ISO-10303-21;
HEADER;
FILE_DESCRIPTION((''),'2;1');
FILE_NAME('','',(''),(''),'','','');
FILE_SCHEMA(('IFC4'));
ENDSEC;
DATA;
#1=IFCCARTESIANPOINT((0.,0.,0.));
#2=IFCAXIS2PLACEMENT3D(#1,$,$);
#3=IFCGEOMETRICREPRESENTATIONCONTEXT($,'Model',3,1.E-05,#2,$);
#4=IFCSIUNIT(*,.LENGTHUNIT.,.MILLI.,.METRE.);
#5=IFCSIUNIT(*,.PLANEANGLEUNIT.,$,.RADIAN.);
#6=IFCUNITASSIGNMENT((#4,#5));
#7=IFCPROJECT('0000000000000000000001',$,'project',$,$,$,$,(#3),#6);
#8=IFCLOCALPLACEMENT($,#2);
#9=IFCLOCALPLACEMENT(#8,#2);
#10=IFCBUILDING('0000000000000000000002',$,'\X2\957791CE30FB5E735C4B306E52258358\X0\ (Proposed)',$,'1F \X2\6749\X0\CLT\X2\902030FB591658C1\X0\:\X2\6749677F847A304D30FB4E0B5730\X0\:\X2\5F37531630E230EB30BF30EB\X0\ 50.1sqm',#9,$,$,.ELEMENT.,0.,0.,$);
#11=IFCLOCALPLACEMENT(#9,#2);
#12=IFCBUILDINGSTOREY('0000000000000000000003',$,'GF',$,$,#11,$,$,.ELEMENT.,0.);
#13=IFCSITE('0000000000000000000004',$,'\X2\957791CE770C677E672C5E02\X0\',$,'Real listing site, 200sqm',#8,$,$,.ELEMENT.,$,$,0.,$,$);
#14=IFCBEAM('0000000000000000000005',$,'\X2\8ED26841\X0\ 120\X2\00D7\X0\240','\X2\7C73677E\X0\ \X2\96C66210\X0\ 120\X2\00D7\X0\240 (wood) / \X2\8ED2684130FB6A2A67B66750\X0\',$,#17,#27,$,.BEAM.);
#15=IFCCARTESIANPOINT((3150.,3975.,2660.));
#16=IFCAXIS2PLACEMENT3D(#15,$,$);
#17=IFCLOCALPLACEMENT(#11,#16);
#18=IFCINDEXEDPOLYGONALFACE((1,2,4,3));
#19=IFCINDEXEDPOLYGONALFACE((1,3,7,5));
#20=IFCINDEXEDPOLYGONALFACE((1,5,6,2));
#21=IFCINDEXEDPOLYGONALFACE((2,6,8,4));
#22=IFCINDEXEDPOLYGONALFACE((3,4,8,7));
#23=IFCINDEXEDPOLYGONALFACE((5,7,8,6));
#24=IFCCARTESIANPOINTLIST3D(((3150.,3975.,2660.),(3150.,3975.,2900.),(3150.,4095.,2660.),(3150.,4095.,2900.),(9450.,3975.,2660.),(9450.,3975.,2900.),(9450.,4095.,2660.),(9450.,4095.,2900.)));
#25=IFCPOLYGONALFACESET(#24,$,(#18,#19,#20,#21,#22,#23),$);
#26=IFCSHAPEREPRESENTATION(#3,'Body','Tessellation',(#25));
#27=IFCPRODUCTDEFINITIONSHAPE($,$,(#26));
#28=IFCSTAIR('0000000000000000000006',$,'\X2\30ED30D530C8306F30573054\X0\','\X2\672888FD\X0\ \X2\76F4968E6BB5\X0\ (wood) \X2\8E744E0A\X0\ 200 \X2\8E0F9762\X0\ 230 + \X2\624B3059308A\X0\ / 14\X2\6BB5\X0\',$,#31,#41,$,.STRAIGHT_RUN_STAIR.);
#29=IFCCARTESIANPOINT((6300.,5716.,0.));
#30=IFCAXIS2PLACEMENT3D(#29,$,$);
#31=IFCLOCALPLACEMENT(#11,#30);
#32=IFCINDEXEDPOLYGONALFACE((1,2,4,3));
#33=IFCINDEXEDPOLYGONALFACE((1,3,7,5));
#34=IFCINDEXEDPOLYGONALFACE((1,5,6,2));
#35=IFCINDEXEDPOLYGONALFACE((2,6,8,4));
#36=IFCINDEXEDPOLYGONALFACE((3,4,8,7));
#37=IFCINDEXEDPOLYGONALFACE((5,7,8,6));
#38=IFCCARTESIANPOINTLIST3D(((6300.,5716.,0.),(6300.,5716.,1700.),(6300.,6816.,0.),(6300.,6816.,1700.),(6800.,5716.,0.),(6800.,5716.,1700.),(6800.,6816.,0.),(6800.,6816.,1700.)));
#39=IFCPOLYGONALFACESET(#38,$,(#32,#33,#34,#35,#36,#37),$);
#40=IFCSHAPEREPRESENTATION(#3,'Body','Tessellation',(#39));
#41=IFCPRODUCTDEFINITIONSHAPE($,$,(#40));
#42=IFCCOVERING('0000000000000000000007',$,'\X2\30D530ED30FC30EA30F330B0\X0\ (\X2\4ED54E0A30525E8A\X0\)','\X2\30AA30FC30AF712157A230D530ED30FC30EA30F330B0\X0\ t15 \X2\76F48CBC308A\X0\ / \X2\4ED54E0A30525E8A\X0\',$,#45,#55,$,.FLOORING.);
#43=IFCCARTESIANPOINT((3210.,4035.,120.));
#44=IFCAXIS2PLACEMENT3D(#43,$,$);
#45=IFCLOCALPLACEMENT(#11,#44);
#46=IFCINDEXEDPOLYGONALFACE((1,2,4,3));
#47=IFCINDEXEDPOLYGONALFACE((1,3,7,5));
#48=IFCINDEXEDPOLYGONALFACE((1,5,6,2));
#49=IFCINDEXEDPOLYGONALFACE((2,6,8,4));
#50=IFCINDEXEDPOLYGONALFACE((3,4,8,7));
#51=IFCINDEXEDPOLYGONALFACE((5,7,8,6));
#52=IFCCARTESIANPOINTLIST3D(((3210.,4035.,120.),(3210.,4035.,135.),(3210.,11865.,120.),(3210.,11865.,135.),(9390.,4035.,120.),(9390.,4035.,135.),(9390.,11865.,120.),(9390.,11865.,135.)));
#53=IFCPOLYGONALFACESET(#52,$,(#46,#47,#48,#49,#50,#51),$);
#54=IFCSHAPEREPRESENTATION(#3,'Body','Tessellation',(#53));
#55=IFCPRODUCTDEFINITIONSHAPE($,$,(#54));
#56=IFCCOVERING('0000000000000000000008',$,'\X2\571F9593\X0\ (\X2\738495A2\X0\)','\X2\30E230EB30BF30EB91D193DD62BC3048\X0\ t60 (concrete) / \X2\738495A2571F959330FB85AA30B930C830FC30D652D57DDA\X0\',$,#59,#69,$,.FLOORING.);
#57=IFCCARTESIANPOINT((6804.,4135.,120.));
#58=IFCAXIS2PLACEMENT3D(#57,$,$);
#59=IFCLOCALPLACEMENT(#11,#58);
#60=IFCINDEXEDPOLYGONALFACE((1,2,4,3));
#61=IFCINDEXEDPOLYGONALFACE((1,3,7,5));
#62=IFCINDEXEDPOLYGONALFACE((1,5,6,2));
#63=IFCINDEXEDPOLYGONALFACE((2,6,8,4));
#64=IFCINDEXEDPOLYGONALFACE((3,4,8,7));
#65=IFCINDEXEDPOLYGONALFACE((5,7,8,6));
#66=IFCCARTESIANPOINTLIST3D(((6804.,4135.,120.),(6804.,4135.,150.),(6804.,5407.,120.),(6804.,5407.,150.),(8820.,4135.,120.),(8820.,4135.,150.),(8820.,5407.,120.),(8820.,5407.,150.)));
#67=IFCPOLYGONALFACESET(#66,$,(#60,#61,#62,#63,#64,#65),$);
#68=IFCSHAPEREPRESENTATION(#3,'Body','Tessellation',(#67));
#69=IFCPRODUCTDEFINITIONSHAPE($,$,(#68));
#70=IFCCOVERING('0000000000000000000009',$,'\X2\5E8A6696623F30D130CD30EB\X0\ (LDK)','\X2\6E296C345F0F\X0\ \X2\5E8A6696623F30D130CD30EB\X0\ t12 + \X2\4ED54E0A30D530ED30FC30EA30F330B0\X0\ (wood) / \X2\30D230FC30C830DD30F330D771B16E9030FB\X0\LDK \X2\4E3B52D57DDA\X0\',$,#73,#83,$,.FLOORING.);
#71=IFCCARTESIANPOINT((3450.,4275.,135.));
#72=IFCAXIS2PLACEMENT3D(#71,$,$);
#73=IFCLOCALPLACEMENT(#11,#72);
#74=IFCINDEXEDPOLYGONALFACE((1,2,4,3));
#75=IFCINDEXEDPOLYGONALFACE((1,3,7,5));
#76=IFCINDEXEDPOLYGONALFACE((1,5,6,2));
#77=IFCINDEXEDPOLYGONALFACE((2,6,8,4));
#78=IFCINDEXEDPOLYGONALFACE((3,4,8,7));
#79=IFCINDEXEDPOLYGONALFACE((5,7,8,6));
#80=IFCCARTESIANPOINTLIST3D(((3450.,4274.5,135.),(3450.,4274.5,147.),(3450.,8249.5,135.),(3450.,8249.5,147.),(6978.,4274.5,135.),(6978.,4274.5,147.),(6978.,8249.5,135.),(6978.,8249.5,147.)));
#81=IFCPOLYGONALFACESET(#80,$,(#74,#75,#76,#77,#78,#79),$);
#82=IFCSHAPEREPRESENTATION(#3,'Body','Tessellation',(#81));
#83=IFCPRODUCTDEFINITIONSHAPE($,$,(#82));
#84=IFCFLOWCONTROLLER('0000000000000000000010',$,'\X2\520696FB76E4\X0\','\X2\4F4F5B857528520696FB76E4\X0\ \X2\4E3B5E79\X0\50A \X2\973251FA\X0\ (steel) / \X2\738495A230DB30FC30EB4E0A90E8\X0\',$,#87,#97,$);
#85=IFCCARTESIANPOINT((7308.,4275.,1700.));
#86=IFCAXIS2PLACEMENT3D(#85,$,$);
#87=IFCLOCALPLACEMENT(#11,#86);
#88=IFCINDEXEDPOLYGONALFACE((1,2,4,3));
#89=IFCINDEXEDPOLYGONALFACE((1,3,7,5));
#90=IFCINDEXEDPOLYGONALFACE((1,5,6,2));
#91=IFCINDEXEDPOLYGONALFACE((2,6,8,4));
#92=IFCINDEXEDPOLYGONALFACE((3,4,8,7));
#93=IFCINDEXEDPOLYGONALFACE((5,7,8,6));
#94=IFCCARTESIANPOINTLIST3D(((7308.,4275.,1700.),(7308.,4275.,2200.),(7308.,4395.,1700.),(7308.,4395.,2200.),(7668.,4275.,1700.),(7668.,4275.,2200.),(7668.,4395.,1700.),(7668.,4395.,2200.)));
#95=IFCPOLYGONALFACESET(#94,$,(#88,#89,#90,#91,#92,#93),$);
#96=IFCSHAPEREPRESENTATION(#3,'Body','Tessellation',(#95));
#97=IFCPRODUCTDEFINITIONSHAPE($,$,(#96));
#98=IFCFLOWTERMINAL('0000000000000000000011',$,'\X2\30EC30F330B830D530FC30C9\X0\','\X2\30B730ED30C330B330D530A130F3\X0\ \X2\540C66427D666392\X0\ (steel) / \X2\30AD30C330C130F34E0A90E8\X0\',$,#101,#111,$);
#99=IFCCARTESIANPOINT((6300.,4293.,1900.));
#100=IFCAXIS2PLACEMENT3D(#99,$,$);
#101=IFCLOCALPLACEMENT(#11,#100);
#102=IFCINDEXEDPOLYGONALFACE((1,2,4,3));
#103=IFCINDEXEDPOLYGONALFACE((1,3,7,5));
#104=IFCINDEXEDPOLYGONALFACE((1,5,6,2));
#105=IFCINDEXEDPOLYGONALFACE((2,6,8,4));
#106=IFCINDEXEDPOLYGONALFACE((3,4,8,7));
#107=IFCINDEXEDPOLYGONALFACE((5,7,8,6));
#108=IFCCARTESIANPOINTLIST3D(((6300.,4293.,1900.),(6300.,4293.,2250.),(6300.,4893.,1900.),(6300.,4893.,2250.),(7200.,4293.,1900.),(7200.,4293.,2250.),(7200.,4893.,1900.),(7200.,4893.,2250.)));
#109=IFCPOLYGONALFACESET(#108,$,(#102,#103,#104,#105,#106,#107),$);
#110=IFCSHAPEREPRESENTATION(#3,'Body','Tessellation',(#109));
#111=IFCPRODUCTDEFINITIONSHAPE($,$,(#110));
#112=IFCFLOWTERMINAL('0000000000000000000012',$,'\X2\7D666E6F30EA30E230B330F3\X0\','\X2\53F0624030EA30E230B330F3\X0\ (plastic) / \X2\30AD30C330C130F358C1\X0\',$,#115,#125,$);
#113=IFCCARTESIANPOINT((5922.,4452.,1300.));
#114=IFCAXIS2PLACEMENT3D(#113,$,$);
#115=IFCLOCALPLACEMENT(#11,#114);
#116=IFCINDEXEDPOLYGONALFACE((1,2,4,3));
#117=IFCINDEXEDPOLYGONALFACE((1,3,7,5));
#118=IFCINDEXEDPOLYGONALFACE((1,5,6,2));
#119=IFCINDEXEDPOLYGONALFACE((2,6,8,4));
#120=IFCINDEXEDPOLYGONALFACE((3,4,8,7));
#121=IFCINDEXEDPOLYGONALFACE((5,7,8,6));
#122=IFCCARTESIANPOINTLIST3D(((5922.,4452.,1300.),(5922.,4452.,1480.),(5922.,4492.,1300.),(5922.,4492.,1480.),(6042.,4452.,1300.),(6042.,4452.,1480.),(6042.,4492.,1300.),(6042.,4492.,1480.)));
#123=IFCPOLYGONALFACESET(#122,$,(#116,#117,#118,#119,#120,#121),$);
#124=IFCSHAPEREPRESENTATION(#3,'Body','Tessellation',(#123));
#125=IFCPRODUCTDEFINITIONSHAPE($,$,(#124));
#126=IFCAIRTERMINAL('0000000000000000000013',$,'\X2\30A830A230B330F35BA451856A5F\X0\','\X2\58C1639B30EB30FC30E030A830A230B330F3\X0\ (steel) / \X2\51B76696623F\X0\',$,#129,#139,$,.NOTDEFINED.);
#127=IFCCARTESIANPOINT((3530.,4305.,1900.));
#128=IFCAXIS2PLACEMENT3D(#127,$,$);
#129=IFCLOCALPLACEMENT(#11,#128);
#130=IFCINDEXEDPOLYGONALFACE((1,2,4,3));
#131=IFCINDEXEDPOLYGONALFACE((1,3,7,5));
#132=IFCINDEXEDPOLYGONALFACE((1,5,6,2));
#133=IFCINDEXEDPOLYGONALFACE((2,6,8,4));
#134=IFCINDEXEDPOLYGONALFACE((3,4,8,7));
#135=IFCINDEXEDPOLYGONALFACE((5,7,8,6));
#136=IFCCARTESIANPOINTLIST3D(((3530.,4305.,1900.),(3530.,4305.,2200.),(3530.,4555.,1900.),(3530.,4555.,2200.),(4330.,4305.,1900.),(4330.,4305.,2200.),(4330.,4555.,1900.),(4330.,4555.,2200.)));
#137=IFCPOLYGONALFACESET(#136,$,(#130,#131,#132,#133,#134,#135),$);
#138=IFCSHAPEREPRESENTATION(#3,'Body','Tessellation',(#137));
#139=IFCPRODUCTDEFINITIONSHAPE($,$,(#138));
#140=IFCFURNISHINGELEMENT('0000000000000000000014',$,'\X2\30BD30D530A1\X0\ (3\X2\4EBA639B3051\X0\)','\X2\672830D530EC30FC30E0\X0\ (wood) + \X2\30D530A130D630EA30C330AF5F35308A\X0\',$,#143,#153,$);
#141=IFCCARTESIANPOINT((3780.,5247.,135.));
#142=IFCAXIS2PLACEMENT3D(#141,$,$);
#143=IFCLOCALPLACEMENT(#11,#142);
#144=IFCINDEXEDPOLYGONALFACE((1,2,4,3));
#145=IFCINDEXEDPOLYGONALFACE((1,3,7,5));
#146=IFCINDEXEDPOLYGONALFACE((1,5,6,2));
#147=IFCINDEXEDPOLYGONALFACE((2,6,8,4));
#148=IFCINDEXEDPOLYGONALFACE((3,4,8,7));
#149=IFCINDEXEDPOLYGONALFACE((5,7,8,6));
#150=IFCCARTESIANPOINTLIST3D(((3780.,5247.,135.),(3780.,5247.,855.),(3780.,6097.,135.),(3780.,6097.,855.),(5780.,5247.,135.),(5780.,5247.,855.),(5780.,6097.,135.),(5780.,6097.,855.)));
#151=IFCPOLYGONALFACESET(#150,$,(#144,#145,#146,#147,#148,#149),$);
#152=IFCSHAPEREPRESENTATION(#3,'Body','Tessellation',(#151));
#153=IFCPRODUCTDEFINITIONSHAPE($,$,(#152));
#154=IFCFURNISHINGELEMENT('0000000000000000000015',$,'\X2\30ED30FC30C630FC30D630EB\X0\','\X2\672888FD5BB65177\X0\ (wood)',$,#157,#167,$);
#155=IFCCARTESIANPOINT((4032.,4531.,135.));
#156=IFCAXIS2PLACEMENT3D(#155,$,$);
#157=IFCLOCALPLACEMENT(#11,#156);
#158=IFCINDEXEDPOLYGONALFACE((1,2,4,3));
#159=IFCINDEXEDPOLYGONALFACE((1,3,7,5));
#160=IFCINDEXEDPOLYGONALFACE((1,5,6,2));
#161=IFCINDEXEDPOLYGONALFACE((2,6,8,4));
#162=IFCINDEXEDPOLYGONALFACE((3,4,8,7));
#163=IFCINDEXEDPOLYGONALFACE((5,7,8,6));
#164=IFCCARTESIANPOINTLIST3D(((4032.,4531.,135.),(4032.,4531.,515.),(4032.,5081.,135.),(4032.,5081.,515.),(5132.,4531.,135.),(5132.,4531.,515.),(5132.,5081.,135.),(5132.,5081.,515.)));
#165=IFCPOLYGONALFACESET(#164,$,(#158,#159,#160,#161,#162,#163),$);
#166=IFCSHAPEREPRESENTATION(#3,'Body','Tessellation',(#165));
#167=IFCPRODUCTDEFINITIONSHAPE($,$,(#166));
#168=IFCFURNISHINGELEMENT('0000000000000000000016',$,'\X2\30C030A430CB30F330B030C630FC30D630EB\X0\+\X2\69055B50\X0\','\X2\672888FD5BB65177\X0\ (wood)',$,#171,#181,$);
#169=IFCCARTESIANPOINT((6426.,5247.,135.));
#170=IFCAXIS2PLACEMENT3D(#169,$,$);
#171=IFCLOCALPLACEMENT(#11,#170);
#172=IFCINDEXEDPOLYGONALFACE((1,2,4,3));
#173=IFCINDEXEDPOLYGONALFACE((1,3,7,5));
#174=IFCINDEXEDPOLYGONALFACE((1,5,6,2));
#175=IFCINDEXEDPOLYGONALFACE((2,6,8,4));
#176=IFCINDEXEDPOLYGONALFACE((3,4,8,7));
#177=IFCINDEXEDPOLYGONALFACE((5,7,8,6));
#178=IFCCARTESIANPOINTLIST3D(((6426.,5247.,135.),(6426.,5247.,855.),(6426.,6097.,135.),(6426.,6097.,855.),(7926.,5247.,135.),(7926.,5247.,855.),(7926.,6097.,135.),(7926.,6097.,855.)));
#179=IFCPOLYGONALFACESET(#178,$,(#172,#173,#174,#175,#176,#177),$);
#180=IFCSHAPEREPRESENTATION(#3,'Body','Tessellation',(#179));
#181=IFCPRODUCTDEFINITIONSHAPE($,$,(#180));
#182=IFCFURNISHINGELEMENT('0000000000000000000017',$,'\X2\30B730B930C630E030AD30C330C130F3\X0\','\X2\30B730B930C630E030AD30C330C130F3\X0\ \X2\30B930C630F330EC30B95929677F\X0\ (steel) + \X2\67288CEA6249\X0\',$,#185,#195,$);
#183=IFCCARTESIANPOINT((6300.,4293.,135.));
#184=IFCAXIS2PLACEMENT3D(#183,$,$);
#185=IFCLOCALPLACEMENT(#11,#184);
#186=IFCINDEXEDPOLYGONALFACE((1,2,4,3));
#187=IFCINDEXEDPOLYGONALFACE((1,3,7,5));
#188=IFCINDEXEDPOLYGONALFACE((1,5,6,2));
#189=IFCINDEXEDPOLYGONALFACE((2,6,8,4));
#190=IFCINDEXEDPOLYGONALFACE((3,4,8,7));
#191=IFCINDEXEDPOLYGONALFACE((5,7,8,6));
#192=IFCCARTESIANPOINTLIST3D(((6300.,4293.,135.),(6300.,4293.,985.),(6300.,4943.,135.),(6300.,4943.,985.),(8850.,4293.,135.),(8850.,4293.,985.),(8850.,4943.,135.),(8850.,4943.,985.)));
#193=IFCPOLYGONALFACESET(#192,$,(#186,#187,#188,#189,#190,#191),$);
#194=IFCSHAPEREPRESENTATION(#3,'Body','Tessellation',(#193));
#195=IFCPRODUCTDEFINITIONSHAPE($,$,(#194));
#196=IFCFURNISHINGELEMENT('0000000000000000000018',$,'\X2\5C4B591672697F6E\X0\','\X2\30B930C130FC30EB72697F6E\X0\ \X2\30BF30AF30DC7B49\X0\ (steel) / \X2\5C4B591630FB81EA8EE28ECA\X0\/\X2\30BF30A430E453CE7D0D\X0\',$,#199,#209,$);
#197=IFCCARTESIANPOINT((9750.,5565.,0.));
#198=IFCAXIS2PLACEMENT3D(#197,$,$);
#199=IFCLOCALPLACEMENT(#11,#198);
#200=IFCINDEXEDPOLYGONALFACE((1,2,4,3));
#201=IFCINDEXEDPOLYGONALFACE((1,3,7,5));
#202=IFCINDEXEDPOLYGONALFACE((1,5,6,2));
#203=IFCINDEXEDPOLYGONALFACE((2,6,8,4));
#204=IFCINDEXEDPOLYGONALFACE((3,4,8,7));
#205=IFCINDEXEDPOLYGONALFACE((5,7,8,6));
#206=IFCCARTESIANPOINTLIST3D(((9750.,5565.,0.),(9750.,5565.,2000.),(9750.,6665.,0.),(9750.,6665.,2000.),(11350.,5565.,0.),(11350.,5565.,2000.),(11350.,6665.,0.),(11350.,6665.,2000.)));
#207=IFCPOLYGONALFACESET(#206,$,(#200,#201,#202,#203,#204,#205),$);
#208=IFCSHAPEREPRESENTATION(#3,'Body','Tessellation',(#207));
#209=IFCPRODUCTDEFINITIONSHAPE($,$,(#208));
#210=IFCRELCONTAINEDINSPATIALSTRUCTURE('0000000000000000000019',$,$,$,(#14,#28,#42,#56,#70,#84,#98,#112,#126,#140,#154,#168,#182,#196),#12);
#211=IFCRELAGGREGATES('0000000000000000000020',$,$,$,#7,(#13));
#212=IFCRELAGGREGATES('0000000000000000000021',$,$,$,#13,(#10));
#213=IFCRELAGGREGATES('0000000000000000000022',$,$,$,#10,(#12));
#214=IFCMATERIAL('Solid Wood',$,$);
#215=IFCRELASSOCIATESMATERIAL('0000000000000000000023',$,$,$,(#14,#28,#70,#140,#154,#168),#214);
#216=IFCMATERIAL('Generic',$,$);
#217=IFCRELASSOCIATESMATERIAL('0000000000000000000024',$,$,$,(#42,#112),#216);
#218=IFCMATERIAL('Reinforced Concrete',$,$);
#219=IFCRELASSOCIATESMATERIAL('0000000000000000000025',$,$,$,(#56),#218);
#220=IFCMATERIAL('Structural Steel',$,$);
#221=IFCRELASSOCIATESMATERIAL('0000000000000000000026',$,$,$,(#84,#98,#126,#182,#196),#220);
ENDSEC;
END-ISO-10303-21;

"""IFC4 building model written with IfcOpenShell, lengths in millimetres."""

from ifc_helpers import new_model, si_unit, frame, frame_2d, origin, place, context, project, spatial, rectangle, extrude, material, element, save


model = new_model("IFC4")

# Units and contexts
model_context = context("Model", 3, precision=1e-05, world=origin())
ifc_project = project(units=[si_unit("LENGTHUNIT", "METRE", prefix="MILLI"), si_unit("PLANEANGLEUNIT", "RADIAN")], contexts=[model_context])

# Site, building, storey
site_placement = place(None, origin())
site = spatial("IfcSite", under=ifc_project, at=site_placement, Name="長野県松本市", ObjectType="Real listing site, 200sqm", CompositionType="ELEMENT", RefElevation=0.0)
building_placement = place(site_placement, origin())
building = spatial("IfcBuilding", under=site, at=building_placement, Name="長野・平屋の別荘 (Proposed)", ObjectType="1F 杉CLT造・外壁:杉板葺き・下地:強化モルタル 50.1sqm", CompositionType="ELEMENT", ElevationOfRefHeight=0.0, ElevationOfTerrain=0.0)
storey_placement = place(building_placement, origin())
storey = spatial("IfcBuildingStorey", under=building, at=storey_placement, Name="GF", CompositionType="ELEMENT", Elevation=0.0)

# Beam
ifc_material_1 = material(Name="Solid Wood")
beam_1_placement = place(storey_placement, frame((3150.0, 3975.0, 2660.0)))
element("IfcBeam", 1, at=beam_1_placement, inside=storey, material=ifc_material_1, Name="軒桁 120×240", Description="米松 集成 120×240 (wood) / 軒桁・横架材", PredefinedType="BEAM", context=model_context, shape_type="SweptSolid", body=[
    extrude(rectangle(XDim=6300.0, YDim=120.0, at=frame_2d((3150.0, 60.0))), frame((3150.0, 3975.0, 2660.0)), (0.0, 0.0, 1.0), 240.0),
])

# Stair
stair_placement = place(storey_placement, frame((6300.0, 5716.0, 0.0)))
element("IfcStair", 2, at=stair_placement, inside=storey, material=ifc_material_1, Name="ロフトはしご", Description="木製 直階段 (wood) 蹴上 200 踏面 230 + 手すり / 14段", PredefinedType="STRAIGHT_RUN_STAIR", context=model_context, shape_type="SweptSolid", body=[
    extrude(rectangle(XDim=500.0, YDim=1100.0, at=frame_2d((250.0, 550.0))), frame((6300.0, 5716.0, 0.0)), (0.0, 0.0, 1.0), 1700.0),
])

# Coverings
ifc_material_2 = material(Name="Generic")
covering_1_placement = place(storey_placement, frame((3210.0, 4035.0, 120.0)))
element("IfcCovering", 3, at=covering_1_placement, inside=storey, material=ifc_material_2, Name="フローリング (仕上げ床)", Description="オーク無垢フローリング t15 直貼り / 仕上げ床", PredefinedType="FLOORING", context=model_context, shape_type="SweptSolid", body=[
    extrude(rectangle(XDim=6180.0, YDim=7830.0, at=frame_2d((3090.0, 3915.0))), frame((3210.0, 4035.0, 120.0)), (0.0, 0.0, 1.0), 15.0),
])
ifc_material_3 = material(Name="Reinforced Concrete")
covering_2_placement = place(storey_placement, frame((6804.0, 4135.0, 120.0)))
element("IfcCovering", 4, at=covering_2_placement, inside=storey, material=ifc_material_3, Name="土間 (玄関)", Description="モルタル金鏝押え t60 (concrete) / 玄関土間・薪ストーブ動線", PredefinedType="FLOORING", context=model_context, shape_type="SweptSolid", body=[
    extrude(rectangle(XDim=2016.0, YDim=1272.0, at=frame_2d((1008.0, 636.0))), frame((6804.0, 4135.0, 120.0)), (0.0, 0.0, 1.0), 30.0),
])
covering_3_placement = place(storey_placement, frame((3450.0, 4275.0, 135.0)))
element("IfcCovering", 5, at=covering_3_placement, inside=storey, material=ifc_material_1, Name="床暖房パネル (LDK)", Description="温水式 床暖房パネル t12 + 仕上フローリング (wood) / ヒートポンプ熱源・LDK 主動線", PredefinedType="FLOORING", context=model_context, shape_type="SweptSolid", body=[
    extrude(rectangle(XDim=3528.0, YDim=3975.0, at=frame_2d((1764.0, 1987.0))), frame((3450.0, 4275.0, 135.0)), (0.0, 0.0, 1.0), 12.0),
])

# Flow controller
ifc_material_4 = material(Name="Structural Steel")
flow_controller_placement = place(storey_placement, frame((7308.0, 4275.0, 1700.0)))
element("IfcFlowController", 6, at=flow_controller_placement, inside=storey, material=ifc_material_4, Name="分電盤", Description="住宅用分電盤 主幹50A 露出 (steel) / 玄関ホール上部", context=model_context, shape_type="SweptSolid", body=[
    extrude(rectangle(XDim=360.0, YDim=120.0, at=frame_2d((180.0, 60.0))), frame((7308.0, 4275.0, 1700.0)), (0.0, 0.0, 1.0), 500.0),
])

# Flow terminals
flow_terminal_1_placement = place(storey_placement, frame((6300.0, 4293.0, 1900.0)))
element("IfcFlowTerminal", 7, at=flow_terminal_1_placement, inside=storey, material=ifc_material_4, Name="レンジフード", Description="シロッコファン 同時給排 (steel) / キッチン上部", context=model_context, shape_type="SweptSolid", body=[
    extrude(rectangle(XDim=900.0, YDim=600.0, at=frame_2d((450.0, 300.0))), frame((6300.0, 4293.0, 1900.0)), (0.0, 0.0, 1.0), 350.0),
])
flow_terminal_2_placement = place(storey_placement, frame((5922.0, 4452.0, 1300.0)))
element("IfcFlowTerminal", 8, at=flow_terminal_2_placement, inside=storey, material=ifc_material_2, Name="給湯リモコン", Description="台所リモコン (plastic) / キッチン壁", context=model_context, shape_type="SweptSolid", body=[
    extrude(rectangle(XDim=120.0, YDim=40.0, at=frame_2d((60.0, 20.0))), frame((5922.0, 4452.0, 1300.0)), (0.0, 0.0, 1.0), 180.0),
])

# Air terminal
air_terminal_placement = place(storey_placement, frame((3530.0, 4305.0, 1900.0)))
element("IfcAirTerminal", 9, at=air_terminal_placement, inside=storey, material=ifc_material_4, Name="エアコン室内機", Description="壁掛ルームエアコン (steel) / 冷暖房", PredefinedType="NOTDEFINED", context=model_context, shape_type="SweptSolid", body=[
    extrude(rectangle(XDim=800.0, YDim=250.0, at=frame_2d((400.0, 125.0))), frame((3530.0, 4305.0, 1900.0)), (0.0, 0.0, 1.0), 300.0),
])

# Furnishing elements
furnishing_1_placement = place(storey_placement, frame((3780.0, 5247.0, 135.0)))
element("IfcFurnishingElement", 10, at=furnishing_1_placement, inside=storey, material=ifc_material_1, Name="ソファ (3人掛け)", Description="木フレーム (wood) + ファブリック張り", context=model_context, shape_type="SweptSolid", body=[
    extrude(rectangle(XDim=2000.0, YDim=850.0, at=frame_2d((1000.0, 425.0))), frame((3780.0, 5247.0, 135.0)), (0.0, 0.0, 1.0), 720.0),
])
furnishing_2_placement = place(storey_placement, frame((4032.0, 4531.0, 135.0)))
element("IfcFurnishingElement", 11, at=furnishing_2_placement, inside=storey, material=ifc_material_1, Name="ローテーブル", Description="木製家具 (wood)", context=model_context, shape_type="SweptSolid", body=[
    extrude(rectangle(XDim=1100.0, YDim=550.0, at=frame_2d((550.0, 275.0))), frame((4032.0, 4531.0, 135.0)), (0.0, 0.0, 1.0), 380.0),
])
furnishing_3_placement = place(storey_placement, frame((6426.0, 5247.0, 135.0)))
element("IfcFurnishingElement", 12, at=furnishing_3_placement, inside=storey, material=ifc_material_1, Name="ダイニングテーブル+椅子", Description="木製家具 (wood)", context=model_context, shape_type="SweptSolid", body=[
    extrude(rectangle(XDim=1500.0, YDim=850.0, at=frame_2d((750.0, 425.0))), frame((6426.0, 5247.0, 135.0)), (0.0, 0.0, 1.0), 720.0),
])
furnishing_4_placement = place(storey_placement, frame((6300.0, 4293.0, 135.0)))
element("IfcFurnishingElement", 13, at=furnishing_4_placement, inside=storey, material=ifc_material_4, Name="システムキッチン", Description="システムキッチン ステンレス天板 (steel) + 木質扉", context=model_context, shape_type="SweptSolid", body=[
    extrude(rectangle(XDim=2550.0, YDim=650.0, at=frame_2d((1275.0, 325.0))), frame((6300.0, 4293.0, 135.0)), (0.0, 0.0, 1.0), 850.0),
])
furnishing_5_placement = place(storey_placement, frame((9750.0, 5565.0, 0.0)))
element("IfcFurnishingElement", 14, at=furnishing_5_placement, inside=storey, material=ifc_material_4, Name="屋外物置", Description="スチール物置 タクボ等 (steel) / 屋外・自転車/タイヤ収納", context=model_context, shape_type="SweptSolid", body=[
    extrude(rectangle(XDim=1600.0, YDim=1100.0, at=frame_2d((800.0, 550.0))), frame((9750.0, 5565.0, 0.0)), (0.0, 0.0, 1.0), 2000.0),
])

save(model, "model.ifc")
